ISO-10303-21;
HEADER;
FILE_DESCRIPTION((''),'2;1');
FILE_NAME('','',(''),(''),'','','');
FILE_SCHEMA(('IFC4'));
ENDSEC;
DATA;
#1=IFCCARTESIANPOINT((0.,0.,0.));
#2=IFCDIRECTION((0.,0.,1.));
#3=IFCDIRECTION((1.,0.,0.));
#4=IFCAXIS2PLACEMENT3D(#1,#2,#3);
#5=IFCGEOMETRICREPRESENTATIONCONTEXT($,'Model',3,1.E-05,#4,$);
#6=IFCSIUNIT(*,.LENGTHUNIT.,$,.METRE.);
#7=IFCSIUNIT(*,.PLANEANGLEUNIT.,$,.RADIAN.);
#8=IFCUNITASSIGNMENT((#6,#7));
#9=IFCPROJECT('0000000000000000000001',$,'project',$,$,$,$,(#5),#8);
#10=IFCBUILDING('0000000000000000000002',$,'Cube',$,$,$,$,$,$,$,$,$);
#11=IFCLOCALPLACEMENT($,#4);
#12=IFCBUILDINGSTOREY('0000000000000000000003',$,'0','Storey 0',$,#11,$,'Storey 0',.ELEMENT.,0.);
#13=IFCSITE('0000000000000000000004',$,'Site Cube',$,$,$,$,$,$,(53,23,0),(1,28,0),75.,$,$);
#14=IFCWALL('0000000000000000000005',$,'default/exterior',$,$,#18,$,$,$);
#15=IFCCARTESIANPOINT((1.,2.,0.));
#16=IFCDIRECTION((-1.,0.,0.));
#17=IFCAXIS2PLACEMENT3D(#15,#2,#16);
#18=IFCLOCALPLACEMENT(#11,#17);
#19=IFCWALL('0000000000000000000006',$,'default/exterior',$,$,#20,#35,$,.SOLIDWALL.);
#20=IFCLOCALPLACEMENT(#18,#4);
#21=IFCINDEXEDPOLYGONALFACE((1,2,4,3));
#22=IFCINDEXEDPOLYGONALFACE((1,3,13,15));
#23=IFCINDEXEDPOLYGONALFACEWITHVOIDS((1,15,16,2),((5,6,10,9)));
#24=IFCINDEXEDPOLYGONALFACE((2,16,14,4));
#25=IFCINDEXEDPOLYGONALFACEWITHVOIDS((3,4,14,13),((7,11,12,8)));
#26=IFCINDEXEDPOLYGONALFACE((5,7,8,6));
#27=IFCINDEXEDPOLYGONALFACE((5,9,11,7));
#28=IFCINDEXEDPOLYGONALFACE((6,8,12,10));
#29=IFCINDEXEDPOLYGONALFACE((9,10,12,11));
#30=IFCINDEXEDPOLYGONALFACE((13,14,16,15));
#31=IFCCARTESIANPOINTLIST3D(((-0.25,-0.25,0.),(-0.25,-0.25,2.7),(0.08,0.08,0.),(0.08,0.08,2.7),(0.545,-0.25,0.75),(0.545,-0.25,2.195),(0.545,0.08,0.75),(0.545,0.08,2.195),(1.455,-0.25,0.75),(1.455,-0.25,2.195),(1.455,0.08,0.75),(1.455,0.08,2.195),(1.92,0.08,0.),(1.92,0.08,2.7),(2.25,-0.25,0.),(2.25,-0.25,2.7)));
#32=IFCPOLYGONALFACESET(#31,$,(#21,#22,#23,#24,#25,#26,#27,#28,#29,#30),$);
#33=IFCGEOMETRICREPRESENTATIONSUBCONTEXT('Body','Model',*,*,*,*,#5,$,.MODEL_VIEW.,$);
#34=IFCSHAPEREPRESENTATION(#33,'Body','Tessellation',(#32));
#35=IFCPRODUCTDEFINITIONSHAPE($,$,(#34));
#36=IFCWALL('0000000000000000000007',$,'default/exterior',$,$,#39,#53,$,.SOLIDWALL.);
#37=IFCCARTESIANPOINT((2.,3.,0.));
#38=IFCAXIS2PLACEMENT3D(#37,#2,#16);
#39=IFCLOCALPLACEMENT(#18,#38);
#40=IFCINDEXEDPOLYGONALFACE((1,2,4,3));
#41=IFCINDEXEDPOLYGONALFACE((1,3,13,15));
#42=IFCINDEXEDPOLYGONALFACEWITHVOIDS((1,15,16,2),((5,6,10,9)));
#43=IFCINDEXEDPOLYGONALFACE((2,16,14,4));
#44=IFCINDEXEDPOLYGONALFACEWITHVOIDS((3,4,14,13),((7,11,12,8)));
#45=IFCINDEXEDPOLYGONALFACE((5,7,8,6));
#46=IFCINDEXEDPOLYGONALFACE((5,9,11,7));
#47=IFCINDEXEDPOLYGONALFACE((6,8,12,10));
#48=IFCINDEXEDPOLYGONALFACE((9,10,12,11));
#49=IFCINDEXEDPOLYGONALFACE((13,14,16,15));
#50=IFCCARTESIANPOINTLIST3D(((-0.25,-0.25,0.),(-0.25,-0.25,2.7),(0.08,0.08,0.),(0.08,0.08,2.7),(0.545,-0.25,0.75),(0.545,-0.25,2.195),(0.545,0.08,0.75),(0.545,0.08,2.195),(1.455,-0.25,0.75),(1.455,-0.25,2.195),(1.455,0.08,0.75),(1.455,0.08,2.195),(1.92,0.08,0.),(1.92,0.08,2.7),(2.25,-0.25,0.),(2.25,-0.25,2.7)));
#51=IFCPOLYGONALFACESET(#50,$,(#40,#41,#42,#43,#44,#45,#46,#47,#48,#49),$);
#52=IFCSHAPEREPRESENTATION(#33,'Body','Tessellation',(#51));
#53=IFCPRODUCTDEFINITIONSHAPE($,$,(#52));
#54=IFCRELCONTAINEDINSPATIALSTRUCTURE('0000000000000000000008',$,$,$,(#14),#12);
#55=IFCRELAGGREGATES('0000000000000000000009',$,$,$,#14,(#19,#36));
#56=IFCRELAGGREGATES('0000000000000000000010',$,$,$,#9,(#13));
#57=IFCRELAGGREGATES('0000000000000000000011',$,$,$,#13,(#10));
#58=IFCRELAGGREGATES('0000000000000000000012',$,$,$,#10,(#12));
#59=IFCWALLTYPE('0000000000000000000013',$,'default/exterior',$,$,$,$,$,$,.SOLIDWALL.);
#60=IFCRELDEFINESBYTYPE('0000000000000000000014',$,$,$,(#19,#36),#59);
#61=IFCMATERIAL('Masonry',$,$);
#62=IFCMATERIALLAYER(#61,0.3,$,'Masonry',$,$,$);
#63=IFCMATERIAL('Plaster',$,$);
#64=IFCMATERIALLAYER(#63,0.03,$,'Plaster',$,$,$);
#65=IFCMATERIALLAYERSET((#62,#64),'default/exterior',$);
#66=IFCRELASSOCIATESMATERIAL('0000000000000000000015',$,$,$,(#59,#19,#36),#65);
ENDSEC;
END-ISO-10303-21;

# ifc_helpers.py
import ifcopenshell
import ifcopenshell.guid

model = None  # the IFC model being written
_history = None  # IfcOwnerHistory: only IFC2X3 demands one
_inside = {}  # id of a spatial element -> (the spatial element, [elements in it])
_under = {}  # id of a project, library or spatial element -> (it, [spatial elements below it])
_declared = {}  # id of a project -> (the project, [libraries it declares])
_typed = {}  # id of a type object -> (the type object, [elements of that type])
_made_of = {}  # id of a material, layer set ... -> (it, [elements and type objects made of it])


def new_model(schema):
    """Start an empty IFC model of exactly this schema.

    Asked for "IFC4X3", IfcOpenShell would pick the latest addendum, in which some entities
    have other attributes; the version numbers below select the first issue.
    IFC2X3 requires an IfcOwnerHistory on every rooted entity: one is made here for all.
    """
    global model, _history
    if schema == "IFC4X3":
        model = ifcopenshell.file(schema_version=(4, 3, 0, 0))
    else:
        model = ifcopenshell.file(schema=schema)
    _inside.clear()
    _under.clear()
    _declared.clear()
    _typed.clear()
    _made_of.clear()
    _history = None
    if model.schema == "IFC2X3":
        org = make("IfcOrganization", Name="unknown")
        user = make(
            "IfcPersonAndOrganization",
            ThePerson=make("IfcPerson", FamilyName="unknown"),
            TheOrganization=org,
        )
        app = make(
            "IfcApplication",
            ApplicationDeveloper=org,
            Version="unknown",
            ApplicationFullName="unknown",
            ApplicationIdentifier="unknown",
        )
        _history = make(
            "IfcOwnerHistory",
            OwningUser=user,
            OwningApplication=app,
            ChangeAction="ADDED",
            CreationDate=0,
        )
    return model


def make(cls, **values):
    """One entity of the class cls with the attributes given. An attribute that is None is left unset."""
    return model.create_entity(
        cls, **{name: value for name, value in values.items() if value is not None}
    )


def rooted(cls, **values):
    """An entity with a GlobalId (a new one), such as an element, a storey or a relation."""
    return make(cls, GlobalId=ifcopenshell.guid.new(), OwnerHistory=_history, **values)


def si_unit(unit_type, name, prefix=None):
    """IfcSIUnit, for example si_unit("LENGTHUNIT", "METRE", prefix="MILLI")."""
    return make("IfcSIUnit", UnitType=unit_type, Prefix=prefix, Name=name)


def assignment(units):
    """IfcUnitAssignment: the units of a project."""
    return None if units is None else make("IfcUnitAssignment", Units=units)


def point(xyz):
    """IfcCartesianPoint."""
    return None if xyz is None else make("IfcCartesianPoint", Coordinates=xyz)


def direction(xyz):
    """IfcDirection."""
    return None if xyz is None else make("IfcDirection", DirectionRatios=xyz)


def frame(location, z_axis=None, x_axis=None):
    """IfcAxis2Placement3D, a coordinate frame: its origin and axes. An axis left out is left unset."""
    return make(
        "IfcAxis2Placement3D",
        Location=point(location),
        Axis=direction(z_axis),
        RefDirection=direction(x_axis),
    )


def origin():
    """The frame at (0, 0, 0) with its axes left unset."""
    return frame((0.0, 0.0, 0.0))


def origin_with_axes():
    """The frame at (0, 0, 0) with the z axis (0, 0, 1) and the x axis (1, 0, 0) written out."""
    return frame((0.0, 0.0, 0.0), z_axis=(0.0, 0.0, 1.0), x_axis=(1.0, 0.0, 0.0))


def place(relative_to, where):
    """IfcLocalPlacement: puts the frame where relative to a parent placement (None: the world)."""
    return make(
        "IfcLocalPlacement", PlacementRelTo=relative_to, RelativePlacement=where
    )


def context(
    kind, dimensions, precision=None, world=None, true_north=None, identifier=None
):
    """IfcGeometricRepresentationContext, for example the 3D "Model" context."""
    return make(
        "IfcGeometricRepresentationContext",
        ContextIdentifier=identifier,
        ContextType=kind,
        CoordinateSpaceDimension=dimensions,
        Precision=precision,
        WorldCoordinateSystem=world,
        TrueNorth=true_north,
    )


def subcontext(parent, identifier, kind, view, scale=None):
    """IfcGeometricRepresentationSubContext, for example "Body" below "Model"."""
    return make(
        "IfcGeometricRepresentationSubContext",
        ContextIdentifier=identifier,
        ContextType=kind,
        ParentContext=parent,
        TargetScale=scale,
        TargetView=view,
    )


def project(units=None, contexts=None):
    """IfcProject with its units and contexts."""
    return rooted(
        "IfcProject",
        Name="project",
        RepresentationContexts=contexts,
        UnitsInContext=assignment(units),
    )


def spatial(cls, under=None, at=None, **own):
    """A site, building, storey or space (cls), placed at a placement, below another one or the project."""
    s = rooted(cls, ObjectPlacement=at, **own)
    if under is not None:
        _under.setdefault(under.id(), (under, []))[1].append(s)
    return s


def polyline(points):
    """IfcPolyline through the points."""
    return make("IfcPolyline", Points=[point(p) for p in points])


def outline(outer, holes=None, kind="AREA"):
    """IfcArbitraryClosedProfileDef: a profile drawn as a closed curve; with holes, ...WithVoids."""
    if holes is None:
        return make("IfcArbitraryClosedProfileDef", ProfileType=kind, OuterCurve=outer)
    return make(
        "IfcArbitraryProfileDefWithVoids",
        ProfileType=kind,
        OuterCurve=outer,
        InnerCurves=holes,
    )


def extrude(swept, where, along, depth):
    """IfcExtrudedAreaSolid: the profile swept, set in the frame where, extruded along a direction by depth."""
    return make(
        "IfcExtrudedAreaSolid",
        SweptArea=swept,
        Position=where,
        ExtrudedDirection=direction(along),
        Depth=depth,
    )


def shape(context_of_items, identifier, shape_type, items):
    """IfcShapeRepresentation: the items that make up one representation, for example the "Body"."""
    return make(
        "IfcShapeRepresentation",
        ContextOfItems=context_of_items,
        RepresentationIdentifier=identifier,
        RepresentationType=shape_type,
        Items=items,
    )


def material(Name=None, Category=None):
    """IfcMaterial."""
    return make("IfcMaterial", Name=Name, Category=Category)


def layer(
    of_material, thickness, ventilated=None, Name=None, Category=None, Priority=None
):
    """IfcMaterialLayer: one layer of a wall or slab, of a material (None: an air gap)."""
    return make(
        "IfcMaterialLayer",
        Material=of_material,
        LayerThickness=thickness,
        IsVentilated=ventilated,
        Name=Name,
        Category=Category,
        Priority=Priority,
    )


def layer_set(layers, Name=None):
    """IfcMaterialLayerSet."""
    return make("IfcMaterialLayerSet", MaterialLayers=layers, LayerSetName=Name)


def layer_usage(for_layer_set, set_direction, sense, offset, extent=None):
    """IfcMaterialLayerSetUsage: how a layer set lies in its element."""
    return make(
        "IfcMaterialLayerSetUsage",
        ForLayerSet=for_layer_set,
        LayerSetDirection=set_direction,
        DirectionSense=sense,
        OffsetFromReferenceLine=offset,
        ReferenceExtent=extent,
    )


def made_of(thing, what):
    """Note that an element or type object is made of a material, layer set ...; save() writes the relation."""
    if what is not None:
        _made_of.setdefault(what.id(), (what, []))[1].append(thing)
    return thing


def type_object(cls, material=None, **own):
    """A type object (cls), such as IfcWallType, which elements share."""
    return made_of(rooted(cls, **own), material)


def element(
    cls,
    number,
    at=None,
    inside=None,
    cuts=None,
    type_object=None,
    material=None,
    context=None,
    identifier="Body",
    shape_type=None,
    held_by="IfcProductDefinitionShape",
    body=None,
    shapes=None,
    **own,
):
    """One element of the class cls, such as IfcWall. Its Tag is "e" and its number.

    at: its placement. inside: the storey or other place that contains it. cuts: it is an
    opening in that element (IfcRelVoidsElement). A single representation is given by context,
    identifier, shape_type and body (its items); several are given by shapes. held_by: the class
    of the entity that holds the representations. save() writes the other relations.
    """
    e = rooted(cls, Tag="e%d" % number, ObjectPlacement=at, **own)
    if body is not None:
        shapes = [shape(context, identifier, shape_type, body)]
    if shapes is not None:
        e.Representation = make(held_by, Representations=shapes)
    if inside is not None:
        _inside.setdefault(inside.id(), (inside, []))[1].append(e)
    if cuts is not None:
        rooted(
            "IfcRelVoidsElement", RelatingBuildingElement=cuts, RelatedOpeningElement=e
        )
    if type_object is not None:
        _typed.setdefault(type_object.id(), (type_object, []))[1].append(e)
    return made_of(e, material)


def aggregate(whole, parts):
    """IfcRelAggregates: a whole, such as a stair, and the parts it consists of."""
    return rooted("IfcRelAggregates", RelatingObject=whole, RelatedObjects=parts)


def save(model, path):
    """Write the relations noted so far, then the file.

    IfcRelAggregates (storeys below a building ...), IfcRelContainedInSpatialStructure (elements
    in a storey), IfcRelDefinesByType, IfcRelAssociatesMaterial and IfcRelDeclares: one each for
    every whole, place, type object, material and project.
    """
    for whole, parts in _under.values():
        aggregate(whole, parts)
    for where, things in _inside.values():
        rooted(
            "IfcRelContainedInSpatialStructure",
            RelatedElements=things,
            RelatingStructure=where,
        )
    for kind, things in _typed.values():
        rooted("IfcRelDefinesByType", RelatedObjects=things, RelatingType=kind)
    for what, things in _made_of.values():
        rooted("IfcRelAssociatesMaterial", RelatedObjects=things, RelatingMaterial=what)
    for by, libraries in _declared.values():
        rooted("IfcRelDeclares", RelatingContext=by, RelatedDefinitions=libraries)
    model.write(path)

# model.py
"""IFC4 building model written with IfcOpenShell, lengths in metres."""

from ifc_helpers import new_model, si_unit, frame, origin, origin_with_axes, place, context, subcontext, project, spatial, polyline, outline, extrude, material, layer, layer_set, layer_usage, type_object, element, aggregate, save


model = new_model("IFC4")

# Units and contexts
model_context = context("Model", 3, precision=1e-05, world=origin_with_axes())
body_context = subcontext(model_context, "Body", "Model", "MODEL_VIEW")
ifc_project = project(units=[si_unit("LENGTHUNIT", "METRE"), si_unit("PLANEANGLEUNIT", "RADIAN")], contexts=[model_context])

# Site, building, storey
site = spatial("IfcSite", under=ifc_project, Name="Site Cube", RefLatitude=(53, 23, 0), RefLongitude=(1, 28, 0), RefElevation=75.0)
building = spatial("IfcBuilding", under=site, Name="Cube")
storey_placement = place(None, origin_with_axes())
storey = spatial("IfcBuildingStorey", under=building, at=storey_placement, Name="0", Description="Storey 0", LongName="Storey 0", CompositionType="ELEMENT", Elevation=0.0)

# Walls, openings
wall_1_placement = place(storey_placement, frame((1.0, 2.0, 0.0), z_axis=(0.0, 0.0, 1.0), x_axis=(-1.0, 0.0, 0.0)))
wall_1 = element("IfcWall", 1, at=wall_1_placement, inside=storey, Name="default/exterior")
ifc_material_1 = material(Name="Masonry")
ifc_layer_1 = layer(ifc_material_1, 0.3, Name="Masonry")
ifc_material_2 = material(Name="Plaster")
ifc_layer_2 = layer(ifc_material_2, 0.03, Name="Plaster")
ifc_layer_set_1 = layer_set([ifc_layer_1, ifc_layer_2], Name="default/exterior")
ifc_layer_usage_1 = layer_usage(ifc_layer_set_1, "AXIS2", "POSITIVE", -0.25)
wall_type = type_object("IfcWallType", Name="default/exterior", PredefinedType="SOLIDWALL", material=ifc_layer_set_1)
wall_2_placement = place(wall_1_placement, origin_with_axes())
wall_2 = element("IfcWall", 2, at=wall_2_placement, type_object=wall_type, material=ifc_layer_usage_1, Name="default/exterior", PredefinedType="SOLIDWALL", context=body_context, shape_type="SweptSolid", body=[
    extrude(outline(polyline([(0.08, 0.08), (-0.25, -0.25), (2.25, -0.25), (1.92, 0.08), (0.08, 0.08)])), origin(), (0.0, 0.0, 1.0), 2.7),
])
opening_1_placement = place(None, frame((0.455, 2.25, 0.75), z_axis=(0.0, 0.0, 1.0), x_axis=(-1.0, 0.0, 0.0)))
element("IfcOpeningElement", 3, at=opening_1_placement, cuts=wall_2, PredefinedType="OPENING", context=body_context, shape_type="SweptSolid", body=[
    extrude(outline(polyline([(0.0, -0.02), (0.91, -0.02), (0.91, 0.35), (0.0, 0.35), (0.0, -0.02)])), origin(), (0.0, 0.0, 1.0), 1.445),
])
ifc_layer_usage_2 = layer_usage(ifc_layer_set_1, "AXIS2", "POSITIVE", -0.25)
wall_3_placement = place(wall_1_placement, frame((2.0, 3.0, 0.0), z_axis=(0.0, 0.0, 1.0), x_axis=(-1.0, 0.0, 0.0)))
wall_3 = element("IfcWall", 4, at=wall_3_placement, type_object=wall_type, material=ifc_layer_usage_2, Name="default/exterior", PredefinedType="SOLIDWALL", context=body_context, shape_type="SweptSolid", body=[
    extrude(outline(polyline([(0.08, 0.08), (-0.25, -0.25), (2.25, -0.25), (1.92, 0.08), (0.08, 0.08)])), origin(), (0.0, 0.0, 1.0), 2.7),
])
opening_2_placement = place(None, frame((-0.455, -1.25, 0.75), z_axis=(0.0, 0.0, 1.0), x_axis=(1.0, 0.0, 0.0)))
element("IfcOpeningElement", 5, at=opening_2_placement, cuts=wall_3, PredefinedType="OPENING", context=body_context, shape_type="SweptSolid", body=[
    extrude(outline(polyline([(0.0, -0.02), (0.91, -0.02), (0.91, 0.35), (0.0, 0.35), (0.0, -0.02)])), origin(), (0.0, 0.0, 1.0), 1.445),
])
aggregate(wall_1, [wall_2, wall_3])

save(model, "model.ifc")
